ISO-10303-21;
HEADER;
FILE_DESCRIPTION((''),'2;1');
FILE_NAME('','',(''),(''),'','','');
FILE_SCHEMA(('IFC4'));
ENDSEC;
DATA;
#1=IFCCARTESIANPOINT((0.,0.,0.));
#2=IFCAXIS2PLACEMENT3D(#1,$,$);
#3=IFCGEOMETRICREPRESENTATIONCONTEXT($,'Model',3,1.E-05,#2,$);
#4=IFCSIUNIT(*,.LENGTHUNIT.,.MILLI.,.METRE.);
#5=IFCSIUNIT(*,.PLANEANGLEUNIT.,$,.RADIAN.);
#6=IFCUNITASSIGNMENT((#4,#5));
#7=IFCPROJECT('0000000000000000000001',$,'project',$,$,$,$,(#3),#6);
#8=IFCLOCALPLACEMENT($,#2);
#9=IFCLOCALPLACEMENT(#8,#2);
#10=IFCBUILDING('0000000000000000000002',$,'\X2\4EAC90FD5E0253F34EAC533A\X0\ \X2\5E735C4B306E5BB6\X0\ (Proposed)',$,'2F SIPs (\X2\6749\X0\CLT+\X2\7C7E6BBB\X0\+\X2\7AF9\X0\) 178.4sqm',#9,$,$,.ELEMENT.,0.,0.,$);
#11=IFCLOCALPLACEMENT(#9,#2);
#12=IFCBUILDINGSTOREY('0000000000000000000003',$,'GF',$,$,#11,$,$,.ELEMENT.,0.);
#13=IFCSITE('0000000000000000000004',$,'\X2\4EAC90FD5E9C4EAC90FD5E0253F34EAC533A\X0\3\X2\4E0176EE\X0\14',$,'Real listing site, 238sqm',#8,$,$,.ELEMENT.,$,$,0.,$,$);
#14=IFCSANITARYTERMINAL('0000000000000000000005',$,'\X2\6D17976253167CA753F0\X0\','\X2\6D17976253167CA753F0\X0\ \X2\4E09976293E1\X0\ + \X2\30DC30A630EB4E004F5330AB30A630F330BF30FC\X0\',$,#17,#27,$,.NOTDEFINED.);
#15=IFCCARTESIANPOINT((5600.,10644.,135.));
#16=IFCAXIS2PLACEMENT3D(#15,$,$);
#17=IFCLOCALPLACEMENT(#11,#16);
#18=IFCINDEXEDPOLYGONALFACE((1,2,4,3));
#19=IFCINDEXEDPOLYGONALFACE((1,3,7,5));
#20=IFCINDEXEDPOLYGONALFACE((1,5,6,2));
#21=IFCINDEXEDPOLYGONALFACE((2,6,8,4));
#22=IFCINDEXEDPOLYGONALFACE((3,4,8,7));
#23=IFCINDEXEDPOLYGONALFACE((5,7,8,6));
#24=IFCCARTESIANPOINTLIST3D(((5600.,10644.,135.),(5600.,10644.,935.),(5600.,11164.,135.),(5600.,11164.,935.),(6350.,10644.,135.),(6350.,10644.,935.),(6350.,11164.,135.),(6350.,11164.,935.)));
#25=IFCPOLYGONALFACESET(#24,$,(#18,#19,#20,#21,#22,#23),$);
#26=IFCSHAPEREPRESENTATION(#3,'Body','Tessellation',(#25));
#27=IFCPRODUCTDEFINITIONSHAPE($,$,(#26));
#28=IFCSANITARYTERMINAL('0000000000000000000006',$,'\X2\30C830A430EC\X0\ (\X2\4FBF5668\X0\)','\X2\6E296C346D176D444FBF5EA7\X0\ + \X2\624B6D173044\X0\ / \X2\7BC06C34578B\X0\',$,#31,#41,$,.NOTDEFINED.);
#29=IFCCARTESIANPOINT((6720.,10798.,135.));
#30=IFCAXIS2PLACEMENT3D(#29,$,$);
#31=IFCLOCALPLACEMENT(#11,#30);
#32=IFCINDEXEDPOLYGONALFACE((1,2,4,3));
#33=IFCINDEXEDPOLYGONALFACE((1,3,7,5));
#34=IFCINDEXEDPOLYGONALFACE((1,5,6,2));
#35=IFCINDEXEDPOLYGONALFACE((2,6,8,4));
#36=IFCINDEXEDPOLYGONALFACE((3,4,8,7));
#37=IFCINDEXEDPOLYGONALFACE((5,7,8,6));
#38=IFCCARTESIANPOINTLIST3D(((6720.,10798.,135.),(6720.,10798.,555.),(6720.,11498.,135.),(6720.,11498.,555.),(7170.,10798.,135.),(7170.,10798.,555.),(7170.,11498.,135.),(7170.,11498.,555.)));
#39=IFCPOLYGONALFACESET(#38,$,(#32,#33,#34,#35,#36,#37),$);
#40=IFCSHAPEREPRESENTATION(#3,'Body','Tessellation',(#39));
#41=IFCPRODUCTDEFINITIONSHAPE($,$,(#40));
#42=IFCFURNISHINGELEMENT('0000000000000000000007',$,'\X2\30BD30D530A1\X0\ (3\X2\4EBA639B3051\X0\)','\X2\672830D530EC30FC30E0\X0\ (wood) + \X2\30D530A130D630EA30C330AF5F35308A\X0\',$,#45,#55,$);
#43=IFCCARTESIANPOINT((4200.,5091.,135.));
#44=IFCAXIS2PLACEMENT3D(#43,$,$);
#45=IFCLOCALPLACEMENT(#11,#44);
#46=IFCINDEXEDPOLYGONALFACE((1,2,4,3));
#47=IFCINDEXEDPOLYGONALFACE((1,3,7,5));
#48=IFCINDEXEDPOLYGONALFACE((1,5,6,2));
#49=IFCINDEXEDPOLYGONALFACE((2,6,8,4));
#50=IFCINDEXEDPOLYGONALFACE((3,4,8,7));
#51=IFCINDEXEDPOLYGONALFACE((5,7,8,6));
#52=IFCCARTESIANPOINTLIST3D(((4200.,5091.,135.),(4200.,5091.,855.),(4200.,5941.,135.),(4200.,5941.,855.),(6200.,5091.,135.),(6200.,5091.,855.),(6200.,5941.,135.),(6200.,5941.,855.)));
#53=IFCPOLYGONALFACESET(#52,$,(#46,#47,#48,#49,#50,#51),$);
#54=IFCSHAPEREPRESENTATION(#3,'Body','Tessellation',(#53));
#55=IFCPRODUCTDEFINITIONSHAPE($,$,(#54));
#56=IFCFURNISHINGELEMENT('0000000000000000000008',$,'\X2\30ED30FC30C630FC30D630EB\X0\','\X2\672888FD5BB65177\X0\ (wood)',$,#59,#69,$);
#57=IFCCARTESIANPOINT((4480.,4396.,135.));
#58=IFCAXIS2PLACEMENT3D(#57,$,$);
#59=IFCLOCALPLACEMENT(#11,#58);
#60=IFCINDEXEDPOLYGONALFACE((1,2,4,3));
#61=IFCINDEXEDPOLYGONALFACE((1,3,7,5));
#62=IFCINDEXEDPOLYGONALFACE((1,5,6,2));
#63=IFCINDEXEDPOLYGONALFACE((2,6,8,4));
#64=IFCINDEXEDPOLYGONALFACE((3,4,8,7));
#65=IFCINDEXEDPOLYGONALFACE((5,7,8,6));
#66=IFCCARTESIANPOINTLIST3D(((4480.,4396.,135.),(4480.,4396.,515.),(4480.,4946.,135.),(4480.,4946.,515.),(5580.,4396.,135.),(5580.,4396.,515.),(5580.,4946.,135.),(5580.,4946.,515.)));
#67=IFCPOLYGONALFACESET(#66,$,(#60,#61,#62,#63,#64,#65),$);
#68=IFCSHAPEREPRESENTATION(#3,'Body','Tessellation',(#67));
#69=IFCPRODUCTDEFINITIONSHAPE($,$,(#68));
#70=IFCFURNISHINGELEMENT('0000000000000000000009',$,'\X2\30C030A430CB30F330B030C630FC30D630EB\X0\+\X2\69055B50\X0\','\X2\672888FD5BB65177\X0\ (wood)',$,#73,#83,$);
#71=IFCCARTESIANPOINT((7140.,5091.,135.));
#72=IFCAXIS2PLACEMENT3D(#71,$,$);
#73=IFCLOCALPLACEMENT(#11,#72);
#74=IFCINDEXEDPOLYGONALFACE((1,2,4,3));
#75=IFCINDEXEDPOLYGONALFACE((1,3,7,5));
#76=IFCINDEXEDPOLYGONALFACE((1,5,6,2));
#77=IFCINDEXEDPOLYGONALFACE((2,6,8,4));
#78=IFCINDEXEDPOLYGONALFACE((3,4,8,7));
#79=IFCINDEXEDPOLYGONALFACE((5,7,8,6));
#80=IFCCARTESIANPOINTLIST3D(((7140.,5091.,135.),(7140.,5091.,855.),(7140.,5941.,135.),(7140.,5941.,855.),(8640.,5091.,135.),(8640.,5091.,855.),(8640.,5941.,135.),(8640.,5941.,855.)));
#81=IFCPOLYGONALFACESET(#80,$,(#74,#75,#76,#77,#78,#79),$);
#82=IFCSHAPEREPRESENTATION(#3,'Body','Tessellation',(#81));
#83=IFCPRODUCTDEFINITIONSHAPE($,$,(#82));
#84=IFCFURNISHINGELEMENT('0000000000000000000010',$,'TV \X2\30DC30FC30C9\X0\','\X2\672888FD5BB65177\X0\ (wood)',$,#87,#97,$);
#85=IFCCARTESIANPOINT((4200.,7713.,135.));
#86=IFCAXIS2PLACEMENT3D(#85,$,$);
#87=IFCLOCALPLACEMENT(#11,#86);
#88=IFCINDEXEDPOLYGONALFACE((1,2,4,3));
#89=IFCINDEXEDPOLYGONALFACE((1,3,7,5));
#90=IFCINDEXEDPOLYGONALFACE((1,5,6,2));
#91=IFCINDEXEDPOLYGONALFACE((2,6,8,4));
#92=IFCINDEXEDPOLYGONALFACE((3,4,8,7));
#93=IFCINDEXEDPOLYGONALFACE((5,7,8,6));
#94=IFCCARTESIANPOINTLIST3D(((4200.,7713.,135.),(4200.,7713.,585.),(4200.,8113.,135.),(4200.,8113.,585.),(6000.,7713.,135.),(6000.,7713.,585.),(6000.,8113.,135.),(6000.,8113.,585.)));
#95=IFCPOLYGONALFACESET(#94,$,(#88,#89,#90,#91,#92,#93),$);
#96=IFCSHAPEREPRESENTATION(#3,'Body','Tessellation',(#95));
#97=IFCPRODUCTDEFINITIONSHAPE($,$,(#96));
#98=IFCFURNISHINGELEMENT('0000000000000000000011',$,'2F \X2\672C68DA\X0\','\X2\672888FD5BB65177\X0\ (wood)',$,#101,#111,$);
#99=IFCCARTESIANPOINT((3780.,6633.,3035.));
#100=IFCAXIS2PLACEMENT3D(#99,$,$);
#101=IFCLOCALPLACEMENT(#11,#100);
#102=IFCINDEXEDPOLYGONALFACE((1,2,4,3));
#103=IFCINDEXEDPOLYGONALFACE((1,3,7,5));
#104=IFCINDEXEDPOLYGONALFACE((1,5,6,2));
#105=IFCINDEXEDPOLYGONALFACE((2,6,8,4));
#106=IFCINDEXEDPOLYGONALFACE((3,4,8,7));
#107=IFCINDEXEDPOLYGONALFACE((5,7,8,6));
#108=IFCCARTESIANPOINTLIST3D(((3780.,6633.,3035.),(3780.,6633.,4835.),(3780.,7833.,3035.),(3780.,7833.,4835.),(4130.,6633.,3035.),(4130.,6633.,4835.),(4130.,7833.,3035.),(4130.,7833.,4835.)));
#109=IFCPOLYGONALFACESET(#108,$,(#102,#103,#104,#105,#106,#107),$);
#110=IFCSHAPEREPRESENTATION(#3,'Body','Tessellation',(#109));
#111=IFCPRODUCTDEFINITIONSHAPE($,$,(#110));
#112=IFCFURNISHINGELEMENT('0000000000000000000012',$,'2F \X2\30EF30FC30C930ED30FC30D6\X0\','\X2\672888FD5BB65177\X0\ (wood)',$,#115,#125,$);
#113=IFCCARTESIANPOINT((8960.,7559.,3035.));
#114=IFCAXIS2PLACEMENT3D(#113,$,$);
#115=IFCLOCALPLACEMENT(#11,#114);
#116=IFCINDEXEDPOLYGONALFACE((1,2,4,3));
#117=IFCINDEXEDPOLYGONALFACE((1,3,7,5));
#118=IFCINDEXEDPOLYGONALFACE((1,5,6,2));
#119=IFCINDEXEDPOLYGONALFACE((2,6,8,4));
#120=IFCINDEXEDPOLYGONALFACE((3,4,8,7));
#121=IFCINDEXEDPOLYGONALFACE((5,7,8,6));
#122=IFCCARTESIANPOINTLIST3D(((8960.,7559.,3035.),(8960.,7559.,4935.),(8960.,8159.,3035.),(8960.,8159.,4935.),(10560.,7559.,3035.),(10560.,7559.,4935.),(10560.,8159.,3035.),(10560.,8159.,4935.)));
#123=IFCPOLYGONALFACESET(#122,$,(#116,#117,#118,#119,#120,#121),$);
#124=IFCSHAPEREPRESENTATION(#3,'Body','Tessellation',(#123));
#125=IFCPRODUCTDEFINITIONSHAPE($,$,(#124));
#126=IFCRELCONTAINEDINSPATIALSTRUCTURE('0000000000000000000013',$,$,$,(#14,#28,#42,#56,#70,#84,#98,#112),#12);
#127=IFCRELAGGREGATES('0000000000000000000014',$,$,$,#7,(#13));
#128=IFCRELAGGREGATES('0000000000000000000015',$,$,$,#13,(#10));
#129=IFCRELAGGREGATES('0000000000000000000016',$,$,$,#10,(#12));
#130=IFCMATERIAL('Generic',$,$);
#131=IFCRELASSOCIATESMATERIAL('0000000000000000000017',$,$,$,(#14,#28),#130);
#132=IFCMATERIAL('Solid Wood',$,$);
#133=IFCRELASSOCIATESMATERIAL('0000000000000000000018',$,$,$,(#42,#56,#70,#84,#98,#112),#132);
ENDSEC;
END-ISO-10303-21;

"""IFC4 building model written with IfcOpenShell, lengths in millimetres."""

from ifc_helpers import new_model, si_unit, frame, frame_2d, origin, place, context, project, spatial, rectangle, extrude, material, element, save


model = new_model("IFC4")

# Units and contexts
model_context = context("Model", 3, precision=1e-05, world=origin())
ifc_project = project(units=[si_unit("LENGTHUNIT", "METRE", prefix="MILLI"), si_unit("PLANEANGLEUNIT", "RADIAN")], contexts=[model_context])

# Site, building, storey
site_placement = place(None, origin())
site = spatial("IfcSite", under=ifc_project, at=site_placement, Name="京都府京都市右京区3丁目14", ObjectType="Real listing site, 238sqm", CompositionType="ELEMENT", RefElevation=0.0)
building_placement = place(site_placement, origin())
building = spatial("IfcBuilding", under=site, at=building_placement, Name="京都市右京区 平屋の家 (Proposed)", ObjectType="2F SIPs (杉CLT+籾殻+竹) 178.4sqm", CompositionType="ELEMENT", ElevationOfRefHeight=0.0, ElevationOfTerrain=0.0)
storey_placement = place(building_placement, origin())
storey = spatial("IfcBuildingStorey", under=building, at=storey_placement, Name="GF", CompositionType="ELEMENT", Elevation=0.0)

# Shared definitions
ifc_material_1 = material(Name="Generic")

# Shared definitions
ifc_material_2 = material(Name="Solid Wood")

# Sanitary terminals
sanitary_terminal_1_placement = place(storey_placement, frame((5600.0, 10644.0, 135.0)))
element("IfcSanitaryTerminal", 1, at=sanitary_terminal_1_placement, inside=storey, material=ifc_material_1, Name="洗面化粧台", Description="洗面化粧台 三面鏡 + ボウル一体カウンター", PredefinedType="NOTDEFINED", context=model_context, shape_type="SweptSolid", body=[
    extrude(rectangle(XDim=750.0, YDim=520.0, at=frame_2d((375.0, 260.0))), frame((5600.0, 10644.0, 135.0)), (0.0, 0.0, 1.0), 800.0),
])
sanitary_terminal_2_placement = place(storey_placement, frame((6720.0, 10798.0, 135.0)))
element("IfcSanitaryTerminal", 2, at=sanitary_terminal_2_placement, inside=storey, material=ifc_material_1, Name="トイレ (便器)", Description="温水洗浄便座 + 手洗い / 節水型", PredefinedType="NOTDEFINED", context=model_context, shape_type="SweptSolid", body=[
    extrude(rectangle(XDim=450.0, YDim=700.0, at=frame_2d((225.0, 350.0))), frame((6720.0, 10798.0, 135.0)), (0.0, 0.0, 1.0), 420.0),
])

# Furnishing elements
furnishing_1_placement = place(storey_placement, frame((4200.0, 5091.0, 135.0)))
element("IfcFurnishingElement", 3, at=furnishing_1_placement, inside=storey, material=ifc_material_2, Name="ソファ (3人掛け)", Description="木フレーム (wood) + ファブリック張り", context=model_context, shape_type="SweptSolid", body=[
    extrude(rectangle(XDim=2000.0, YDim=850.0, at=frame_2d((1000.0, 425.0))), frame((4200.0, 5091.0, 135.0)), (0.0, 0.0, 1.0), 720.0),
])
furnishing_2_placement = place(storey_placement, frame((4480.0, 4396.0, 135.0)))
element("IfcFurnishingElement", 4, at=furnishing_2_placement, inside=storey, material=ifc_material_2, Name="ローテーブル", Description="木製家具 (wood)", context=model_context, shape_type="SweptSolid", body=[
    extrude(rectangle(XDim=1100.0, YDim=550.0, at=frame_2d((550.0, 275.0))), frame((4480.0, 4396.0, 135.0)), (0.0, 0.0, 1.0), 380.0),
])
furnishing_3_placement = place(storey_placement, frame((7140.0, 5091.0, 135.0)))
element("IfcFurnishingElement", 5, at=furnishing_3_placement, inside=storey, material=ifc_material_2, Name="ダイニングテーブル+椅子", Description="木製家具 (wood)", context=model_context, shape_type="SweptSolid", body=[
    extrude(rectangle(XDim=1500.0, YDim=850.0, at=frame_2d((750.0, 425.0))), frame((7140.0, 5091.0, 135.0)), (0.0, 0.0, 1.0), 720.0),
])
furnishing_4_placement = place(storey_placement, frame((4200.0, 7713.0, 135.0)))
element("IfcFurnishingElement", 6, at=furnishing_4_placement, inside=storey, material=ifc_material_2, Name="TV ボード", Description="木製家具 (wood)", context=model_context, shape_type="SweptSolid", body=[
    extrude(rectangle(XDim=1800.0, YDim=400.0, at=frame_2d((900.0, 200.0))), frame((4200.0, 7713.0, 135.0)), (0.0, 0.0, 1.0), 450.0),
])
furnishing_5_placement = place(storey_placement, frame((3780.0, 6633.0, 3035.0)))
element("IfcFurnishingElement", 7, at=furnishing_5_placement, inside=storey, material=ifc_material_2, Name="2F 本棚", Description="木製家具 (wood)", context=model_context, shape_type="SweptSolid", body=[
    extrude(rectangle(XDim=350.0, YDim=1200.0, at=frame_2d((175.0, 600.0))), frame((3780.0, 6633.0, 3035.0)), (0.0, 0.0, 1.0), 1800.0),
])
furnishing_6_placement = place(storey_placement, frame((8960.0, 7559.0, 3035.0)))
element("IfcFurnishingElement", 8, at=furnishing_6_placement, inside=storey, material=ifc_material_2, Name="2F ワードローブ", Description="木製家具 (wood)", context=model_context, shape_type="SweptSolid", body=[
    extrude(rectangle(XDim=1600.0, YDim=600.0, at=frame_2d((800.0, 300.0))), frame((8960.0, 7559.0, 3035.0)), (0.0, 0.0, 1.0), 1900.0),
])

save(model, "model.ifc")
